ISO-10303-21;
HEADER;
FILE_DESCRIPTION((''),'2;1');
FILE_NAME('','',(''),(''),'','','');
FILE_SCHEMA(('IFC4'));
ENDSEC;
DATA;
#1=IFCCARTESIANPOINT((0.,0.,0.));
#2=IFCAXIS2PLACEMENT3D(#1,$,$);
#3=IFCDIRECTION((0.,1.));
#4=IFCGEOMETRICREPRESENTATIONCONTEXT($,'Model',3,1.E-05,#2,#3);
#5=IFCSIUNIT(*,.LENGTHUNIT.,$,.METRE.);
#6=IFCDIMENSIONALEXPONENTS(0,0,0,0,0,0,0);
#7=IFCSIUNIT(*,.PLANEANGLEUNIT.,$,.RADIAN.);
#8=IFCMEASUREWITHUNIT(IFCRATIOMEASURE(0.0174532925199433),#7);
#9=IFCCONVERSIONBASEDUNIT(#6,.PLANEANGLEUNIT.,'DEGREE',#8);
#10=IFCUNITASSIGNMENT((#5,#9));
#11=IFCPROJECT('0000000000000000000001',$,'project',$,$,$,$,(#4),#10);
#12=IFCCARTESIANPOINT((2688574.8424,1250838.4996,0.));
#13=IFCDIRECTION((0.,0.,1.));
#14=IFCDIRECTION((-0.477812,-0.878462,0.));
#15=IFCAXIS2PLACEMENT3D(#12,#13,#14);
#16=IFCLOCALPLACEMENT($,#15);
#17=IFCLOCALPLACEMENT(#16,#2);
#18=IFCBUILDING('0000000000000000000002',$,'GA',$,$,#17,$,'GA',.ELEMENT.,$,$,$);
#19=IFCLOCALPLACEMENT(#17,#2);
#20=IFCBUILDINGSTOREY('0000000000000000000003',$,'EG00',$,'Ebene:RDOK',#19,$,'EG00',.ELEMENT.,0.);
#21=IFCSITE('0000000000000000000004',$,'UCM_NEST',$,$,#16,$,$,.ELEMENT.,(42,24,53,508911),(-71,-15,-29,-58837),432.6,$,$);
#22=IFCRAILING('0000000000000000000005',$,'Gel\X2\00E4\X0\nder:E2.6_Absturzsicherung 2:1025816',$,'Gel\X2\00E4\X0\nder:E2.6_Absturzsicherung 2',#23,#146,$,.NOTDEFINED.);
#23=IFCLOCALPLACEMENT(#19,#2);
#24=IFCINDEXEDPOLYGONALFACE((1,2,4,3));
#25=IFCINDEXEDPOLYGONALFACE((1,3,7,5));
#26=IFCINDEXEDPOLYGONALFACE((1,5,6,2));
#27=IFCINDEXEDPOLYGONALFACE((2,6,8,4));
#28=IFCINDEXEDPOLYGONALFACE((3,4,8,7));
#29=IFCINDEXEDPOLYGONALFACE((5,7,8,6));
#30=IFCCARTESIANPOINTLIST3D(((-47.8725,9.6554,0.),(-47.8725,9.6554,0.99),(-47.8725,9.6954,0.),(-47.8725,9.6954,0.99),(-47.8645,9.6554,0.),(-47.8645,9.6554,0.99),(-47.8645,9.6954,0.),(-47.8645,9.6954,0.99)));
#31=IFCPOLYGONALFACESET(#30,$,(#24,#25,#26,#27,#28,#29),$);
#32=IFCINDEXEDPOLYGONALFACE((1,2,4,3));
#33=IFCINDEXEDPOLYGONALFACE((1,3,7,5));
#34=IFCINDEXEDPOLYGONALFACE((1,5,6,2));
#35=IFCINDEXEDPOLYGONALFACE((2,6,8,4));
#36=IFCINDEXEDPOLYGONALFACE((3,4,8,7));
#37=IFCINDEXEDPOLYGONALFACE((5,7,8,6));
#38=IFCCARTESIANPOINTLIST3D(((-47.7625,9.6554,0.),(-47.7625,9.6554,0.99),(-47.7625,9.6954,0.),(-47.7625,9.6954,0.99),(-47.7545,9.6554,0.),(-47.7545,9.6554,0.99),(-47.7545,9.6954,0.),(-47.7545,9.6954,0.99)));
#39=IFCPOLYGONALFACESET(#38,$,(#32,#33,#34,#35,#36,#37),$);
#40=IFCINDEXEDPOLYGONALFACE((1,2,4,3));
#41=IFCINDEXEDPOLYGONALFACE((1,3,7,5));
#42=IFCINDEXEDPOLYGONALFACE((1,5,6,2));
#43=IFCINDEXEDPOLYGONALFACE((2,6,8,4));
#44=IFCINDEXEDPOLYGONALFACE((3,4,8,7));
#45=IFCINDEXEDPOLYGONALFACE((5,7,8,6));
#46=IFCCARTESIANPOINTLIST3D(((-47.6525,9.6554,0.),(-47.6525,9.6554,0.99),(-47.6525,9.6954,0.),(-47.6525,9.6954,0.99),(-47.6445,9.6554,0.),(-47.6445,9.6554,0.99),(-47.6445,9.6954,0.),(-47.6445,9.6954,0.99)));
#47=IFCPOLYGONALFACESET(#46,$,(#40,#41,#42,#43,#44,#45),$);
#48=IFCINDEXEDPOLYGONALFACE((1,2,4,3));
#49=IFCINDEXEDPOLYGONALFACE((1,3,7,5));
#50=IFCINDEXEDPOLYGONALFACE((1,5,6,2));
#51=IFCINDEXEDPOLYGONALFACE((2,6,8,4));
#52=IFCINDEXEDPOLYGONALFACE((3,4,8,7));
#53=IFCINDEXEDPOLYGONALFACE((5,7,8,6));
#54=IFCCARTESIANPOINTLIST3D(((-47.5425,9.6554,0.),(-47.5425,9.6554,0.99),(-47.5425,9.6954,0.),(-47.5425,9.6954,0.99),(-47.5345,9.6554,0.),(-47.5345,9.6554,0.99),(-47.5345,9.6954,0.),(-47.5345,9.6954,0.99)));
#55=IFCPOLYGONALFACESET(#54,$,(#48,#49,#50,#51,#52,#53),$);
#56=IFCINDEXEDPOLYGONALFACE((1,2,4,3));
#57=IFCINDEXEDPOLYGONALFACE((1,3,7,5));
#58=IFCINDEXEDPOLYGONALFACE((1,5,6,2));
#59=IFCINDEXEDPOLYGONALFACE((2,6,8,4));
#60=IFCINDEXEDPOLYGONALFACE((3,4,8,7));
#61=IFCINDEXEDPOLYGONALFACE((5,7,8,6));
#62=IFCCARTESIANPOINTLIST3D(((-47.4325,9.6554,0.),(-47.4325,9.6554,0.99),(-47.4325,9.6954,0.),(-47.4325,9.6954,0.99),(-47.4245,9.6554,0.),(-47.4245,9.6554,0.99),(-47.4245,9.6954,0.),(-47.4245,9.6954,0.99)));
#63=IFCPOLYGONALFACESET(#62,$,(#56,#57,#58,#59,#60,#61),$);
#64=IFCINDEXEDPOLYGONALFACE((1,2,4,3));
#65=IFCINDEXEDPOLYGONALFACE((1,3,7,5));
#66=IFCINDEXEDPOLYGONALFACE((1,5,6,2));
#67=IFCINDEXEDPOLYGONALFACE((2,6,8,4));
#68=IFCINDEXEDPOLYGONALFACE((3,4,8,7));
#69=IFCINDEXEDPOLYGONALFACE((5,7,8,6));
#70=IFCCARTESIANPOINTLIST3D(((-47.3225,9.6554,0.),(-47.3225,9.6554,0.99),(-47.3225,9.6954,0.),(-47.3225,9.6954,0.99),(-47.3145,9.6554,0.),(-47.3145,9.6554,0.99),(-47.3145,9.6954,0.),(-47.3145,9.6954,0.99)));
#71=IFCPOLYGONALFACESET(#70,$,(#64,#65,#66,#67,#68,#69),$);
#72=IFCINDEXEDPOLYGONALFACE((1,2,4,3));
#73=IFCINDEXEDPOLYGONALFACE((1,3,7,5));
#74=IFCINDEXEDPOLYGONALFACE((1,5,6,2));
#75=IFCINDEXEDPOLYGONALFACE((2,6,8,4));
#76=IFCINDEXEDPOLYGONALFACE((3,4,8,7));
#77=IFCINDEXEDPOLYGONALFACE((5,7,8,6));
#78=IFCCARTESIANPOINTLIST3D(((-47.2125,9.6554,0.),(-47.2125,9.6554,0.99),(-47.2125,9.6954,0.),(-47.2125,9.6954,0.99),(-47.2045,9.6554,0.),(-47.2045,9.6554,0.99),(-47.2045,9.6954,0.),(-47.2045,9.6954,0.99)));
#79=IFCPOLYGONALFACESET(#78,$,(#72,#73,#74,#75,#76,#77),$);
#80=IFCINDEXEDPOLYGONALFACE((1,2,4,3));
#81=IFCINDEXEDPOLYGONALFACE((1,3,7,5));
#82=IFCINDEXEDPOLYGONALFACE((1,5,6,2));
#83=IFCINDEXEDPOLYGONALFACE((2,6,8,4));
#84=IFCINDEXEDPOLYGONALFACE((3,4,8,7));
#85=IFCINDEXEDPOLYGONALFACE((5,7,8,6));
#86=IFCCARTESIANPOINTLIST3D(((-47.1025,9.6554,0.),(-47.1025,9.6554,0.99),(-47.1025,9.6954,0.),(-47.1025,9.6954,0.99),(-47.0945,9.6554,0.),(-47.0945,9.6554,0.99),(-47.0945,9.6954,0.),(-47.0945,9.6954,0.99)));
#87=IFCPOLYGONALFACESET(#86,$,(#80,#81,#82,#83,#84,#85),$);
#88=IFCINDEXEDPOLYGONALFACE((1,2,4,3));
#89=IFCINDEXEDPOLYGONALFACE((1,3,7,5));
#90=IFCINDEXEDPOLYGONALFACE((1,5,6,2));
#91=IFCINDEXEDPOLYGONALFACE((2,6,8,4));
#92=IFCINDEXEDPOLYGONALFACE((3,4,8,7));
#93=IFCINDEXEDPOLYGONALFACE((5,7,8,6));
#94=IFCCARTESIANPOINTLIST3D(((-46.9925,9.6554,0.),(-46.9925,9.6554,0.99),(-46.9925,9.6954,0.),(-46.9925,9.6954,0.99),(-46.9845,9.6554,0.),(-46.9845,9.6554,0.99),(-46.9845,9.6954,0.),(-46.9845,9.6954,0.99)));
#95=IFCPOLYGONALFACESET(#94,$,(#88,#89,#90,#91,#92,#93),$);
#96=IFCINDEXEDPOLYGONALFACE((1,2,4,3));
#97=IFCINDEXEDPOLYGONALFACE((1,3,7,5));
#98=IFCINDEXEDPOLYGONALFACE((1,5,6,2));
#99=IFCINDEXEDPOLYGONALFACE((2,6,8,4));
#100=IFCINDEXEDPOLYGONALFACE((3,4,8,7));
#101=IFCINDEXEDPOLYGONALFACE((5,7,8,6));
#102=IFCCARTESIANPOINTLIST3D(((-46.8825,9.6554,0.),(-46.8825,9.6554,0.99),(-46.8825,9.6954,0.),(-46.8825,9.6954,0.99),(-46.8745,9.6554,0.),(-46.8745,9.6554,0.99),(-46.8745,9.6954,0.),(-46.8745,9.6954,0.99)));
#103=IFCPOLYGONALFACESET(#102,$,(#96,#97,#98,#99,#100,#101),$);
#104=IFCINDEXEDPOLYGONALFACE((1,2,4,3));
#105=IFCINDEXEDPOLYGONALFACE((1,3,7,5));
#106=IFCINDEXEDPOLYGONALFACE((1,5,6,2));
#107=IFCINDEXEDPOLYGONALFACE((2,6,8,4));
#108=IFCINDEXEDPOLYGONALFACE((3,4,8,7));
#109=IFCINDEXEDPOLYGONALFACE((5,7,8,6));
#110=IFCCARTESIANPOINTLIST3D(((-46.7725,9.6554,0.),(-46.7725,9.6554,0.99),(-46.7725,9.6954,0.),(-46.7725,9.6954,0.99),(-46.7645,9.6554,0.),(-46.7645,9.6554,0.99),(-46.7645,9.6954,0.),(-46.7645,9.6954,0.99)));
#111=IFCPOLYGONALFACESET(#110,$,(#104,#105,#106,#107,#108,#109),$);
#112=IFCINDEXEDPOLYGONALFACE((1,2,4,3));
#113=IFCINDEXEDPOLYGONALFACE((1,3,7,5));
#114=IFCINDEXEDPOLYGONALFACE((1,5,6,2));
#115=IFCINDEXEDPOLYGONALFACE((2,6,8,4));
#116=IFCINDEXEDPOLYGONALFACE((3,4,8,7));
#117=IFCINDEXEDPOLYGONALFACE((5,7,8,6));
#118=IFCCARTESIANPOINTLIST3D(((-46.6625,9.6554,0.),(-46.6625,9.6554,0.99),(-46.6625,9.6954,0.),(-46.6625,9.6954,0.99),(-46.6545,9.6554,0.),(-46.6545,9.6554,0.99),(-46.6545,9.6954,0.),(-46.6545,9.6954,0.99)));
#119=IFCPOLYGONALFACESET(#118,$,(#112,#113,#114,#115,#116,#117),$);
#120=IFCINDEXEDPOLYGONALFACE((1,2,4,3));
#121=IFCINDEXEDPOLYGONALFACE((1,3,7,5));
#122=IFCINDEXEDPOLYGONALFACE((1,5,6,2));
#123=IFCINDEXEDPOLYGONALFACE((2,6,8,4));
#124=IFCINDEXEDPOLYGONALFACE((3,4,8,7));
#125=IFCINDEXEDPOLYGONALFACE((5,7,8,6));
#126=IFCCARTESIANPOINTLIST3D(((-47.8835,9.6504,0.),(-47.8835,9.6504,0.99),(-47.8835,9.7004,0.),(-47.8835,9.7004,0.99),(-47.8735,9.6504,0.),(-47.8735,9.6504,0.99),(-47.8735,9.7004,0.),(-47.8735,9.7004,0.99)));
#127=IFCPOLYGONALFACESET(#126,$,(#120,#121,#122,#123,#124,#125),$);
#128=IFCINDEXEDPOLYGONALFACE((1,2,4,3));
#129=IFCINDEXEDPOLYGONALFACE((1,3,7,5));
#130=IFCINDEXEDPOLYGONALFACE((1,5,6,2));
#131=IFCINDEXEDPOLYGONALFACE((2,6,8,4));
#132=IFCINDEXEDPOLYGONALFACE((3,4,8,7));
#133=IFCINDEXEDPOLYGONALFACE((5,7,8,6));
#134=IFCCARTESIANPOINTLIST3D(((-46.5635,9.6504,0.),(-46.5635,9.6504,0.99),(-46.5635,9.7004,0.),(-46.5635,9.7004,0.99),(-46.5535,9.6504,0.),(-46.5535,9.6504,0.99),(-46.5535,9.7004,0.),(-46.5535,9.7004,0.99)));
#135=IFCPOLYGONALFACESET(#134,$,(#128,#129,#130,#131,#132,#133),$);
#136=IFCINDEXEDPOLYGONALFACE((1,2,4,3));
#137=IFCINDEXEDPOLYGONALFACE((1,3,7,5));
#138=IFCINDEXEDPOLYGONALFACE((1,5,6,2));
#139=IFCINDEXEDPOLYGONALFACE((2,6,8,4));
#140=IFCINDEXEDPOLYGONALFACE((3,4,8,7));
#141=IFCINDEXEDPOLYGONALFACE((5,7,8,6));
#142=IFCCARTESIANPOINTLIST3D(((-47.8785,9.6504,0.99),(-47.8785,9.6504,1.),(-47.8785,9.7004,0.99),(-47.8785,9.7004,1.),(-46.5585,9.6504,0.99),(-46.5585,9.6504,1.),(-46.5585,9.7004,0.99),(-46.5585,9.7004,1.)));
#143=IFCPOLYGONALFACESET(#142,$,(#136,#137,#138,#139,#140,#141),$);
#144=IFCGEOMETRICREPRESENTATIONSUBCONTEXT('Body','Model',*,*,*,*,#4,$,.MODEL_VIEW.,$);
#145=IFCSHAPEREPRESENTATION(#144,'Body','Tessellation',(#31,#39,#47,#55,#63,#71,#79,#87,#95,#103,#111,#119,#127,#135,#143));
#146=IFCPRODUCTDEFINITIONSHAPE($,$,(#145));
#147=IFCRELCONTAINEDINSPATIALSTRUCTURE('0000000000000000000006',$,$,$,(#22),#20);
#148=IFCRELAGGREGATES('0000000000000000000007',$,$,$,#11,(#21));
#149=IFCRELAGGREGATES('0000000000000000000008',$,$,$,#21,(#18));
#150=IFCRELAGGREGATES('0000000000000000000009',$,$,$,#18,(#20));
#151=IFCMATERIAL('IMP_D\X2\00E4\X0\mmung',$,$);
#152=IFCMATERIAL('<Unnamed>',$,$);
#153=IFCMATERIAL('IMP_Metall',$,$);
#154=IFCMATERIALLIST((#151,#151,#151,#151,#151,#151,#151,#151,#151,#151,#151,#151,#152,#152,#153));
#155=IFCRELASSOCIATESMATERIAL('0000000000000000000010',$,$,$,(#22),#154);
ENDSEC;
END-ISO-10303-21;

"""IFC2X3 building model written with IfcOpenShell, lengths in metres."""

from ifc_helpers import new_model, entity, si_unit, converted_unit, direction, frame, frame_2d, origin, origin_2d_with_axis, place, context, subcontext, project, spatial, rectangle, extrude, material, material_list, element, save


model = new_model("IFC2X3")

# Units and contexts
model_context = context("Model", 3, precision=1e-05, world=origin(), true_north=direction((0.0, 1.0)))
body_context = subcontext(model_context, "Body", "Model", "MODEL_VIEW")
ifc_project = project(units=[si_unit("LENGTHUNIT", "METRE"), converted_unit("PLANEANGLEUNIT", "DEGREE", entity("IfcRatioMeasure", 0.0174532925199433), si_unit("PLANEANGLEUNIT", "RADIAN"), dimensions=[0, 0, 0, 0, 0, 0, 0])], contexts=[model_context])

# Site, building, storey
site_placement = place(None, frame((2688574.8424, 1250838.4996, 0.0), z_axis=(0.0, 0.0, 1.0), x_axis=(-0.477812, -0.878462, 0.0)))
site = spatial("IfcSite", under=ifc_project, at=site_placement, Name="UCM_NEST", CompositionType="ELEMENT", RefLatitude=(42, 24, 53, 508911), RefLongitude=(-71, -15, -29, -58837), RefElevation=432.6)
building_placement = place(site_placement, origin())
building = spatial("IfcBuilding", under=site, at=building_placement, Name="GA", LongName="GA", CompositionType="ELEMENT")
storey_placement = place(building_placement, origin())
storey = spatial("IfcBuildingStorey", under=building, at=storey_placement, Name="EG00", ObjectType="Ebene:RDOK", LongName="EG00", CompositionType="ELEMENT", Elevation=0.0)

# Shared definitions
ifc_material_1 = material(Name="IMP_Dämmung")

# Railing
ifc_material_2 = material(Name="<Unnamed>")
ifc_material_3 = material(Name="IMP_Metall")
ifc_material_list_1 = material_list([ifc_material_1, ifc_material_1, ifc_material_1, ifc_material_1, ifc_material_1, ifc_material_1, ifc_material_1, ifc_material_1, ifc_material_1, ifc_material_1, ifc_material_1, ifc_material_1, ifc_material_2, ifc_material_2, ifc_material_3])
railing_1_placement = place(storey_placement, origin())
element("IfcRailing", 1, at=railing_1_placement, inside=storey, material=ifc_material_list_1, Name="Geländer:E2.6_Absturzsicherung 2:1025816", ObjectType="Geländer:E2.6_Absturzsicherung 2", PredefinedType="NOTDEFINED", context=body_context, shape_type="SweptSolid", body=[
    extrude(rectangle(XDim=0.008, YDim=0.04, at=origin_2d_with_axis()), frame((-47.8685, 9.6754, 0.0), z_axis=(0.0, 0.0, 1.0), x_axis=(-1.0, 0.0, 0.0)), (0.0, 0.0, 1.0), 0.99),
    extrude(rectangle(XDim=0.008, YDim=0.04, at=origin_2d_with_axis()), frame((-47.7585, 9.6754, 0.0), z_axis=(0.0, 0.0, 1.0), x_axis=(-1.0, 0.0, 0.0)), (0.0, 0.0, 1.0), 0.99),
    extrude(rectangle(XDim=0.008, YDim=0.04, at=origin_2d_with_axis()), frame((-47.6485, 9.6754, 0.0), z_axis=(0.0, 0.0, 1.0), x_axis=(-1.0, 0.0, 0.0)), (0.0, 0.0, 1.0), 0.99),
    extrude(rectangle(XDim=0.008, YDim=0.04, at=origin_2d_with_axis()), frame((-47.5385, 9.6754, 0.0), z_axis=(0.0, 0.0, 1.0), x_axis=(-1.0, 0.0, 0.0)), (0.0, 0.0, 1.0), 0.99),
    extrude(rectangle(XDim=0.008, YDim=0.04, at=origin_2d_with_axis()), frame((-47.4285, 9.6754, 0.0), z_axis=(0.0, 0.0, 1.0), x_axis=(-1.0, 0.0, 0.0)), (0.0, 0.0, 1.0), 0.99),
    extrude(rectangle(XDim=0.008, YDim=0.04, at=origin_2d_with_axis()), frame((-47.3185, 9.6754, 0.0), z_axis=(0.0, 0.0, 1.0), x_axis=(-1.0, 0.0, 0.0)), (0.0, 0.0, 1.0), 0.99),
    extrude(rectangle(XDim=0.008, YDim=0.04, at=origin_2d_with_axis()), frame((-47.2085, 9.6754, 0.0), z_axis=(0.0, 0.0, 1.0), x_axis=(-1.0, 0.0, 0.0)), (0.0, 0.0, 1.0), 0.99),
    extrude(rectangle(XDim=0.008, YDim=0.04, at=origin_2d_with_axis()), frame((-47.0985, 9.6754, 0.0), z_axis=(0.0, 0.0, 1.0), x_axis=(-1.0, 0.0, 0.0)), (0.0, 0.0, 1.0), 0.99),
    extrude(rectangle(XDim=0.008, YDim=0.04, at=origin_2d_with_axis()), frame((-46.9885, 9.6754, 0.0), z_axis=(0.0, 0.0, 1.0), x_axis=(-1.0, 0.0, 0.0)), (0.0, 0.0, 1.0), 0.99),
    extrude(rectangle(XDim=0.008, YDim=0.04, at=origin_2d_with_axis()), frame((-46.8785, 9.6754, 0.0), z_axis=(0.0, 0.0, 1.0), x_axis=(-1.0, 0.0, 0.0)), (0.0, 0.0, 1.0), 0.99),
    extrude(rectangle(XDim=0.008, YDim=0.04, at=origin_2d_with_axis()), frame((-46.7685, 9.6754, 0.0), z_axis=(0.0, 0.0, 1.0), x_axis=(-1.0, 0.0, 0.0)), (0.0, 0.0, 1.0), 0.99),
    extrude(rectangle(XDim=0.008, YDim=0.04, at=origin_2d_with_axis()), frame((-46.6585, 9.6754, 0.0), z_axis=(0.0, 0.0, 1.0), x_axis=(-1.0, 0.0, 0.0)), (0.0, 0.0, 1.0), 0.99),
    extrude(rectangle(XDim=0.01, YDim=0.05, at=frame_2d((0.0, 0.0), x_axis=(1.0, 0.0))), frame((-47.8785, 9.6754, 0.0), z_axis=(0.0, 0.0, 1.0), x_axis=(-1.0, 0.0, 0.0)), (0.0, 0.0, 1.0), 0.99),
    extrude(rectangle(XDim=0.01, YDim=0.05, at=frame_2d((0.0, 0.0), x_axis=(1.0, 0.0))), frame((-46.5585, 9.6754, 0.0), z_axis=(0.0, 0.0, 1.0), x_axis=(-1.0, 0.0, 0.0)), (0.0, 0.0, 1.0), 0.99),
    extrude(rectangle(XDim=1.32, YDim=0.05, at=frame_2d((0.0, 0.0), x_axis=(1.0, 0.0))), frame((-47.2185, 9.6754, 0.99), z_axis=(0.0, 0.0, 1.0), x_axis=(-1.0, 0.0, 0.0)), (0.0, 0.0, 1.0), 0.01),
])

save(model, "model.ifc")
